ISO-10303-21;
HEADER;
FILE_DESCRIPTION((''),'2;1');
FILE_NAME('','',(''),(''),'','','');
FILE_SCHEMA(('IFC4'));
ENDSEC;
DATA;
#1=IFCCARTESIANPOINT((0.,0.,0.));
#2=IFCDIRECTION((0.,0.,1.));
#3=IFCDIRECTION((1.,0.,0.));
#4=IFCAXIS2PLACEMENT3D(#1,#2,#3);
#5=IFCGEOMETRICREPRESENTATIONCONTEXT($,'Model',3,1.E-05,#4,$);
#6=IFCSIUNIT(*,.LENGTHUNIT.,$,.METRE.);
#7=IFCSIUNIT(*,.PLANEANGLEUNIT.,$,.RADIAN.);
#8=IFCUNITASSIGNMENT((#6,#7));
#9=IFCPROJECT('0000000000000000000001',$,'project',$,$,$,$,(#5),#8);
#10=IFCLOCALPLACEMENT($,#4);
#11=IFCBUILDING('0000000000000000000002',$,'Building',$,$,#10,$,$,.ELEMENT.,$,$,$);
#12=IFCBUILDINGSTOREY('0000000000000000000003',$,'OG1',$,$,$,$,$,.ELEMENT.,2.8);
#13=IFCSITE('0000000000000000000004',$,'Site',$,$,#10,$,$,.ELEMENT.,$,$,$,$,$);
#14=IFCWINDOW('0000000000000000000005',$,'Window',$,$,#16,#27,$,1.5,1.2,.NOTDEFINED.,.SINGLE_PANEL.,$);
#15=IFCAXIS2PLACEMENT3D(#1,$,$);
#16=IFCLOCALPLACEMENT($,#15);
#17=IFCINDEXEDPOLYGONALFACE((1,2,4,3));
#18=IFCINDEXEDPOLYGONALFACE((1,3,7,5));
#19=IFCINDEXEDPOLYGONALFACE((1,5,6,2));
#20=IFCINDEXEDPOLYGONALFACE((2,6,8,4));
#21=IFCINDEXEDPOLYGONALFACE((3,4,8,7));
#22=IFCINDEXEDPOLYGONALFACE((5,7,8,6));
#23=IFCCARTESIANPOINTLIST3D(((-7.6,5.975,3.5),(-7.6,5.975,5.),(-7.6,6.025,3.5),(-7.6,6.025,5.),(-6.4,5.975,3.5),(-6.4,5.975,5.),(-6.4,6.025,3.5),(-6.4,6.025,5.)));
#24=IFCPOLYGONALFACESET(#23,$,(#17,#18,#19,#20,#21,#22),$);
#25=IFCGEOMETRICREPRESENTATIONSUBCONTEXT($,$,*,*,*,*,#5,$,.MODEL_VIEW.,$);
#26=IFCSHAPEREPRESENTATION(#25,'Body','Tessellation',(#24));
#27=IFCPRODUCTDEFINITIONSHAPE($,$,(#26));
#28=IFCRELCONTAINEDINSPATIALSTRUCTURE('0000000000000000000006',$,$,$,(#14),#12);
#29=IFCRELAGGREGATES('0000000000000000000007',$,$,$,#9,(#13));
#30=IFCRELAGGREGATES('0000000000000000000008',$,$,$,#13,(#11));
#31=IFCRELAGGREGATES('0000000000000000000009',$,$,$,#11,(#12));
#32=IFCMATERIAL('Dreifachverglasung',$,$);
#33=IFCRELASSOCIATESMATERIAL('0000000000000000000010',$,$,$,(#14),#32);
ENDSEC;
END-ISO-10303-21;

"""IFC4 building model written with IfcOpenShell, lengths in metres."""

from ifc_helpers import new_model, si_unit, frame, origin, origin_with_axes, origin_2d, place, context, subcontext, project, spatial, rectangle, extrude, material, element, save


model = new_model("IFC4")

# Units and contexts
model_context = context("Model", 3, precision=1e-05, world=origin_with_axes())
sub_context = subcontext(model_context, None, None, "MODEL_VIEW")
ifc_project = project(units=[si_unit("LENGTHUNIT", "METRE"), si_unit("PLANEANGLEUNIT", "RADIAN")], contexts=[model_context])

# Site, building, storey
placement_1 = place(None, origin_with_axes())
site = spatial("IfcSite", under=ifc_project, at=placement_1, Name="Site", CompositionType="ELEMENT")
building = spatial("IfcBuilding", under=site, at=placement_1, Name="Building", CompositionType="ELEMENT")
storey = spatial("IfcBuildingStorey", under=building, Name="OG1", CompositionType="ELEMENT", Elevation=2.8)

# Window
ifc_material = material(Name="Dreifachverglasung")
placement_2 = place(None, origin_with_axes())
window_placement = place(placement_2, frame((-7.0, 6.0, 3.5)))
element("IfcWindow", 1, at=window_placement, inside=storey, material=ifc_material, Name="Window", OverallHeight=1.5, OverallWidth=1.2, PartitioningType="SINGLE_PANEL", PredefinedType="NOTDEFINED", context=sub_context, shape_type="SweptSolid", body=[
    extrude(rectangle(XDim=1.2, YDim=0.05, at=origin_2d()), origin(), (0.0, 0.0, 1.0), 1.5),
])

save(model, "model.ifc")
